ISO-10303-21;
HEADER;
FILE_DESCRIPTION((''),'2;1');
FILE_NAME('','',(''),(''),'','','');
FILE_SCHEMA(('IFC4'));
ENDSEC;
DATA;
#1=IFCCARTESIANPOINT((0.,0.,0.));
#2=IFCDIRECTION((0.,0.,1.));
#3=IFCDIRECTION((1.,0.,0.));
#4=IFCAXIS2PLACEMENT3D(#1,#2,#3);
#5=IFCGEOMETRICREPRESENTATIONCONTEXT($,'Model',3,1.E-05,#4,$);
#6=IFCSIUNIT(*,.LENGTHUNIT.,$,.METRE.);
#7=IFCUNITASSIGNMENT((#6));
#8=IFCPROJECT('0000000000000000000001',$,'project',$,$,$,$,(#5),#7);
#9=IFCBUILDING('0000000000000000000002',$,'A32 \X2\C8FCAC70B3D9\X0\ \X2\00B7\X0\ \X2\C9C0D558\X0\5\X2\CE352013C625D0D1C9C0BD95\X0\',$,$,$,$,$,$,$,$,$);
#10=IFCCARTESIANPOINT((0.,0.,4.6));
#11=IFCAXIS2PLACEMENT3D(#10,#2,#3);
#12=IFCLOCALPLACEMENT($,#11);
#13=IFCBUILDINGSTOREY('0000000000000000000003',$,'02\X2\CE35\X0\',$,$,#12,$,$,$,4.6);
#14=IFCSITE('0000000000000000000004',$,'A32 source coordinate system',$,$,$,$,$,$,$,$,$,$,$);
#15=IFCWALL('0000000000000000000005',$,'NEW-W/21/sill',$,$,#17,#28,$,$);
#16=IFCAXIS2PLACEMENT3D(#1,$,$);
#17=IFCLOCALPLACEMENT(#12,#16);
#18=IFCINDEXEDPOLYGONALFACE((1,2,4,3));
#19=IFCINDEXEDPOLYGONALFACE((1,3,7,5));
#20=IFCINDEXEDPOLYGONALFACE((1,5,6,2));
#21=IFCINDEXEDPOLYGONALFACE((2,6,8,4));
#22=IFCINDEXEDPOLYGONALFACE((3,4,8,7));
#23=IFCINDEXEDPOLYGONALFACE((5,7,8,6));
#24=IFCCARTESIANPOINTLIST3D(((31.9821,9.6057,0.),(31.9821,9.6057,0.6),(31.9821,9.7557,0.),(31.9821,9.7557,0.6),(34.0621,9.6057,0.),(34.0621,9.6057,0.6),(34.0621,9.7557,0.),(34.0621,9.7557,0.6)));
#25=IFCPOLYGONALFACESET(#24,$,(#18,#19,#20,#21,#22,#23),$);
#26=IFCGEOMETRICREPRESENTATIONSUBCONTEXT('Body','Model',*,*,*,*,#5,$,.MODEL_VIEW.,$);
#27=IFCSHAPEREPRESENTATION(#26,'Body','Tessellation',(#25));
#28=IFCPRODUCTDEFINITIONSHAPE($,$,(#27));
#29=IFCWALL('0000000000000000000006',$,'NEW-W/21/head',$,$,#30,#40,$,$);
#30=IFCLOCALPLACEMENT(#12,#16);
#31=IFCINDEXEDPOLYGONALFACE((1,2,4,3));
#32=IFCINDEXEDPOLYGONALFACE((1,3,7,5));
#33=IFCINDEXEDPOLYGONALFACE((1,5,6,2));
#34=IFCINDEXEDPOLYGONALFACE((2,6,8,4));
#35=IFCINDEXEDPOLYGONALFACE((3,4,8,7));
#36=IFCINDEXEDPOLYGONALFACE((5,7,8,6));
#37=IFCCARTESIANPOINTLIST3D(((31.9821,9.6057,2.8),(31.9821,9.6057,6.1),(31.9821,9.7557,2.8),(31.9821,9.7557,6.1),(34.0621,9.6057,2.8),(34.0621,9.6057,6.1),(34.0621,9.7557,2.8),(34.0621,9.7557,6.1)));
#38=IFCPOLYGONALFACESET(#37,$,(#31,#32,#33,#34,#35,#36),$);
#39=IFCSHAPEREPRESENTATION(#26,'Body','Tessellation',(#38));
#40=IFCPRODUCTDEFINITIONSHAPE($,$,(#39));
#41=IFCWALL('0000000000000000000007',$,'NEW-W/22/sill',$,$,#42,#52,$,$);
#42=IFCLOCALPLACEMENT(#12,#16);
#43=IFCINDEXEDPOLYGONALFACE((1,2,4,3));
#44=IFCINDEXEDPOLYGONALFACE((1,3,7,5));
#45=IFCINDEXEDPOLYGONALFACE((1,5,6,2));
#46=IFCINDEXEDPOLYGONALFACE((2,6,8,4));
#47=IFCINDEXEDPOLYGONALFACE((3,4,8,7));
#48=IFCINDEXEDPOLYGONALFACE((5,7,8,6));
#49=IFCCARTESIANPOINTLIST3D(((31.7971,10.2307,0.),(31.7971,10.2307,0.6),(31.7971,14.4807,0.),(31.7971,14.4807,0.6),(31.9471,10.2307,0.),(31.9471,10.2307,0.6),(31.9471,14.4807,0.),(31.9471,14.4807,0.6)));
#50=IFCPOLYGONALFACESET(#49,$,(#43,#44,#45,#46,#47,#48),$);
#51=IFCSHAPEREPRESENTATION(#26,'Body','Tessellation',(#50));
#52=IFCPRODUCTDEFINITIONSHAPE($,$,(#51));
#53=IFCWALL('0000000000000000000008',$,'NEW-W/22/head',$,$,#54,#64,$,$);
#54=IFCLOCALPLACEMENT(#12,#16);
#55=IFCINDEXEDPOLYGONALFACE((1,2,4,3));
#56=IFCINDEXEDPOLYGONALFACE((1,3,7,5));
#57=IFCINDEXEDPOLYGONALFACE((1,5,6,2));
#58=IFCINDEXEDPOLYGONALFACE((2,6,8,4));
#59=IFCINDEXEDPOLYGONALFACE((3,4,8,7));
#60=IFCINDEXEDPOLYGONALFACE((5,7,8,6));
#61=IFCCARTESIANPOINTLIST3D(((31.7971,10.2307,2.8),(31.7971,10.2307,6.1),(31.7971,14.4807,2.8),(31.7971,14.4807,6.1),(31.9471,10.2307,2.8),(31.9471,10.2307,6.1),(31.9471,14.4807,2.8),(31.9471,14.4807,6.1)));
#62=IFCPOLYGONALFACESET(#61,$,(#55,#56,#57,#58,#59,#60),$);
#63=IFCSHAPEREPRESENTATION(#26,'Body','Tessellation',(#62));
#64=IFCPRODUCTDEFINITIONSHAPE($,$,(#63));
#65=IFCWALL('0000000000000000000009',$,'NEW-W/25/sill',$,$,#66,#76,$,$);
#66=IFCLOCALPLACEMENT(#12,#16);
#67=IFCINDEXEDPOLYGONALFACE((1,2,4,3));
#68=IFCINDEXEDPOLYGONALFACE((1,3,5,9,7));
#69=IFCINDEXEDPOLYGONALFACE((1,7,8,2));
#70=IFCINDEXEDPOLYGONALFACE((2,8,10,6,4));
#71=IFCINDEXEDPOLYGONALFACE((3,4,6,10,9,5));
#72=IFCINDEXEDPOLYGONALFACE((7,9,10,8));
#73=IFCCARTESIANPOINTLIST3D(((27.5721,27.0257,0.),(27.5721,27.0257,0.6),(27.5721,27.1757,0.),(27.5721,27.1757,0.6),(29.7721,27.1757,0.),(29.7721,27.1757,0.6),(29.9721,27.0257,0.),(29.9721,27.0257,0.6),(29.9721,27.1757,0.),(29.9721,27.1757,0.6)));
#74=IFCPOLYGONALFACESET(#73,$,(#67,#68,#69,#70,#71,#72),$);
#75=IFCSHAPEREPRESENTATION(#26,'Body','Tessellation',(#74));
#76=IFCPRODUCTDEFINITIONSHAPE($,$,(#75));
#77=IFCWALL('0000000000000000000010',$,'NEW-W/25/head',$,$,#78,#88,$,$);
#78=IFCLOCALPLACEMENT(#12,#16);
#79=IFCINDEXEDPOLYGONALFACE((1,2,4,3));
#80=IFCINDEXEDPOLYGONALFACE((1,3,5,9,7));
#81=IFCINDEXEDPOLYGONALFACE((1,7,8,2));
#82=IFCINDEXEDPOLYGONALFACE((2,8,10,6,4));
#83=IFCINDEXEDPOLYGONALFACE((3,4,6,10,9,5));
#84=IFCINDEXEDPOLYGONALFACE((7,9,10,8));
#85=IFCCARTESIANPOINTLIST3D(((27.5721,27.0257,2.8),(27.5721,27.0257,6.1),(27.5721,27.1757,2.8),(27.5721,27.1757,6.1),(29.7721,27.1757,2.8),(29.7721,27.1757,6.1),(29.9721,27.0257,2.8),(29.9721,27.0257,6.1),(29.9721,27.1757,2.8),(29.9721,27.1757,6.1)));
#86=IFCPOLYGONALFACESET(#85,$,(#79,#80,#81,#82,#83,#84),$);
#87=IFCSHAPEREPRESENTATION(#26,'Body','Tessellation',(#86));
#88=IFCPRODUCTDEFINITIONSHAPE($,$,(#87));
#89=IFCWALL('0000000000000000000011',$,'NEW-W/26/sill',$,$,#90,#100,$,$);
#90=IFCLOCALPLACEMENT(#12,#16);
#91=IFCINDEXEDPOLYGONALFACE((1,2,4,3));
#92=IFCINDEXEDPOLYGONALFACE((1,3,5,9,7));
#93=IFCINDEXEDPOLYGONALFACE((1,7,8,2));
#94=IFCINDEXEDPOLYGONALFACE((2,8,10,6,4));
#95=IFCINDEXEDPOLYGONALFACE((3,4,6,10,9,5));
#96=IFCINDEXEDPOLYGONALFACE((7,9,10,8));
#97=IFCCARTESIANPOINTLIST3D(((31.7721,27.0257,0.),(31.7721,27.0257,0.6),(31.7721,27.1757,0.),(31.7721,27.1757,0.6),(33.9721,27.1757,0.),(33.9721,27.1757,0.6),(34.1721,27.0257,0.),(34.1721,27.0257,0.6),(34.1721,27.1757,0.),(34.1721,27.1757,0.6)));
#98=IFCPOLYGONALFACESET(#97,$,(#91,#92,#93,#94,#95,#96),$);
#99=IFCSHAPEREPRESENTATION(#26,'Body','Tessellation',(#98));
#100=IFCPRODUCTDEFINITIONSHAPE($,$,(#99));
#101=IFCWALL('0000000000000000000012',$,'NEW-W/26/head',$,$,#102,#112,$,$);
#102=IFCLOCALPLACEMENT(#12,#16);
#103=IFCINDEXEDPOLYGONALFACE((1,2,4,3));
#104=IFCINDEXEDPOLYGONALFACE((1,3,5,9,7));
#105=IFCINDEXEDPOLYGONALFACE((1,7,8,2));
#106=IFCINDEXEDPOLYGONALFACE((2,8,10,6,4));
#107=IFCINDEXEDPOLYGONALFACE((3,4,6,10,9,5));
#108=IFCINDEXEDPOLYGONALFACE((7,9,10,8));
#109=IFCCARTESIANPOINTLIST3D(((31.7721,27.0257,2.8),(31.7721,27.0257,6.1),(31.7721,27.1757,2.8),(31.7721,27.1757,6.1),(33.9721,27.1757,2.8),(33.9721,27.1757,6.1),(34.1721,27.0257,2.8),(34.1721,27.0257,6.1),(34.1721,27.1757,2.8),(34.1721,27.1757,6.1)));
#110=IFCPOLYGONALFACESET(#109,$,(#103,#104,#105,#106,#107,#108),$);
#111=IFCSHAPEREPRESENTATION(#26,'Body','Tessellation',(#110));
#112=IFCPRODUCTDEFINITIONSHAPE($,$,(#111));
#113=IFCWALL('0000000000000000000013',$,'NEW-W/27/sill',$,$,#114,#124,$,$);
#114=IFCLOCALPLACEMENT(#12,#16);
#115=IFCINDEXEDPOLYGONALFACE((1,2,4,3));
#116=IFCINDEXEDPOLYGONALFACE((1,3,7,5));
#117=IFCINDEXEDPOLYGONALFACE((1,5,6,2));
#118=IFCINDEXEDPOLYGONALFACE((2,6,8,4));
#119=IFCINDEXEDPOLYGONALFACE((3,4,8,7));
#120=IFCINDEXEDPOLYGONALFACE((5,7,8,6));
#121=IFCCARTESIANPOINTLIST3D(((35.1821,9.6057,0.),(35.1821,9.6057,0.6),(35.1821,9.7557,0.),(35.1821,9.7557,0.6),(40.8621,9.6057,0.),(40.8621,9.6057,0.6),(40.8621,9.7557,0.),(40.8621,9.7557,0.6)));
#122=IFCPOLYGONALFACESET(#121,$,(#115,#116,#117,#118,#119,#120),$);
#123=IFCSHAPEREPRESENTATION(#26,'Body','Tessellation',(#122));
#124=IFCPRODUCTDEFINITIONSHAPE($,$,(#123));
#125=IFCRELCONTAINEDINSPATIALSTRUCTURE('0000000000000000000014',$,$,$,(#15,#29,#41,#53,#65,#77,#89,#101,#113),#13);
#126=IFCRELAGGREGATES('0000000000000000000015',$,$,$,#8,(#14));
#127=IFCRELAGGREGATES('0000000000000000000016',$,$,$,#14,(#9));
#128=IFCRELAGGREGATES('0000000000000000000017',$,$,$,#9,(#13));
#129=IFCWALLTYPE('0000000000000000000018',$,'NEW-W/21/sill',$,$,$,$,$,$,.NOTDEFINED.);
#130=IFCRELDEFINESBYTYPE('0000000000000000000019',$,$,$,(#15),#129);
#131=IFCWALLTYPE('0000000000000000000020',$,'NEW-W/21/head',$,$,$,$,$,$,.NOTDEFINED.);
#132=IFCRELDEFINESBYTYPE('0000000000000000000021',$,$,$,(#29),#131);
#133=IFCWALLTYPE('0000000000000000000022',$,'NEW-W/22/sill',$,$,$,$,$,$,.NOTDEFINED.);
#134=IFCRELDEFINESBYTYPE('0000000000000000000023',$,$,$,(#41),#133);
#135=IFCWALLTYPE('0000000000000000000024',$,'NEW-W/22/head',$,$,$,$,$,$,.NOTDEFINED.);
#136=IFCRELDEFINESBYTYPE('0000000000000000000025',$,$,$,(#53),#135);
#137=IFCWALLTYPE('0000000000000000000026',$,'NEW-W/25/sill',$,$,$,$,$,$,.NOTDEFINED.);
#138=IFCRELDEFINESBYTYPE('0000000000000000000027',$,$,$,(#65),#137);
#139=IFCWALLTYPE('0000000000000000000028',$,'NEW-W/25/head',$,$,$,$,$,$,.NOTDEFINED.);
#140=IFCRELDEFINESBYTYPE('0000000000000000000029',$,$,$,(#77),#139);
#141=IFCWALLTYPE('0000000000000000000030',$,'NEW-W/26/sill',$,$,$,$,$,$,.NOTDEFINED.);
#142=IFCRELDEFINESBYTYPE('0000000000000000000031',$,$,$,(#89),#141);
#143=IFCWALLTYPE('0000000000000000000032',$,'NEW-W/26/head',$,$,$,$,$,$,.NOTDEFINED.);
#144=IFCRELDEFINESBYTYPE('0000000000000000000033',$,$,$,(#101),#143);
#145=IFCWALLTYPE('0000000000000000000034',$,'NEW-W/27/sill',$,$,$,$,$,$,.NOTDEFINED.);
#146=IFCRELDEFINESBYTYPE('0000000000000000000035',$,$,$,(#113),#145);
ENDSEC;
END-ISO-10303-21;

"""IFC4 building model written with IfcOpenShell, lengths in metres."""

from ifc_helpers import new_model, si_unit, frame, origin, origin_with_axes, place, context, subcontext, project, spatial, polyline, outline, extrude, source, transform, mapped, type_object, type_shapes, element, save


model = new_model("IFC4")

# Units and contexts
model_context = context("Model", 3, precision=1e-05, world=origin_with_axes())
body_context = subcontext(model_context, "Body", "Model", "MODEL_VIEW")
ifc_project = project(units=[si_unit("LENGTHUNIT", "METRE")], contexts=[model_context])

# Site, building, storey
site = spatial("IfcSite", under=ifc_project, Name="A32 source coordinate system")
building = spatial("IfcBuilding", under=site, Name="A32 주거동 · 지하5층–옥탑지붕")
storey_placement = place(None, frame((0.0, 0.0, 4.6), z_axis=(0.0, 0.0, 1.0), x_axis=(1.0, 0.0, 0.0)))
storey = spatial("IfcBuildingStorey", under=building, at=storey_placement, Name="02층", Elevation=4.6)

# Walls
wall_type_1 = type_object("IfcWallType", Name="NEW-W/21/sill", PredefinedType="NOTDEFINED")
shared_shape_1 = source(origin(), body_context, "Body", "SweptSolid", [
    extrude(outline(polyline([(31.9821, 9.6057), (31.9821, 9.7557), (34.0621, 9.7557), (34.0621, 9.6057), (31.9821, 9.6057)])), origin(), (0.0, 0.0, 1.0), 0.6),
])
type_shapes(wall_type_1, [shared_shape_1])
wall_1_placement = place(storey_placement, origin_with_axes())
element("IfcWall", 1, at=wall_1_placement, inside=storey, type_object=wall_type_1, Name="NEW-W/21/sill", context=body_context, shape_type="MappedRepresentation", body=[
    mapped(shared_shape_1, transform((0.0, 0.0, 0.0), scale=1.0)),
])
wall_type_2 = type_object("IfcWallType", Name="NEW-W/21/head", PredefinedType="NOTDEFINED")
shared_shape_2 = source(origin(), body_context, "Body", "SweptSolid", [
    extrude(outline(polyline([(31.9821, 9.6057), (31.9821, 9.7557), (34.0621, 9.7557), (34.0621, 9.6057), (31.9821, 9.6057)])), frame((0.0, 0.0, 2.8)), (0.0, 0.0, 1.0), 3.3),
])
type_shapes(wall_type_2, [shared_shape_2])
wall_2_placement = place(storey_placement, origin_with_axes())
element("IfcWall", 2, at=wall_2_placement, inside=storey, type_object=wall_type_2, Name="NEW-W/21/head", context=body_context, shape_type="MappedRepresentation", body=[
    mapped(shared_shape_2, transform((0.0, 0.0, 0.0), scale=1.0)),
])
wall_type_3 = type_object("IfcWallType", Name="NEW-W/22/sill", PredefinedType="NOTDEFINED")
shared_shape_3 = source(origin(), body_context, "Body", "SweptSolid", [
    extrude(outline(polyline([(31.7971, 10.2307), (31.7971, 14.4807), (31.9471, 14.4807), (31.9471, 10.2307), (31.7971, 10.2307)])), origin(), (0.0, 0.0, 1.0), 0.6),
])
type_shapes(wall_type_3, [shared_shape_3])
wall_3_placement = place(storey_placement, origin_with_axes())
element("IfcWall", 3, at=wall_3_placement, inside=storey, type_object=wall_type_3, Name="NEW-W/22/sill", context=body_context, shape_type="MappedRepresentation", body=[
    mapped(shared_shape_3, transform((0.0, 0.0, 0.0), scale=1.0)),
])
wall_type_4 = type_object("IfcWallType", Name="NEW-W/22/head", PredefinedType="NOTDEFINED")
shared_shape_4 = source(origin(), body_context, "Body", "SweptSolid", [
    extrude(outline(polyline([(31.7971, 10.2307), (31.7971, 14.4807), (31.9471, 14.4807), (31.9471, 10.2307), (31.7971, 10.2307)])), frame((0.0, 0.0, 2.8)), (0.0, 0.0, 1.0), 3.3),
])
type_shapes(wall_type_4, [shared_shape_4])
wall_4_placement = place(storey_placement, origin_with_axes())
element("IfcWall", 4, at=wall_4_placement, inside=storey, type_object=wall_type_4, Name="NEW-W/22/head", context=body_context, shape_type="MappedRepresentation", body=[
    mapped(shared_shape_4, transform((0.0, 0.0, 0.0), scale=1.0)),
])
wall_type_5 = type_object("IfcWallType", Name="NEW-W/25/sill", PredefinedType="NOTDEFINED")
shared_shape_5 = source(origin(), body_context, "Body", "SweptSolid", [
    extrude(outline(polyline([(29.9721, 27.0257), (27.5721, 27.0257), (27.5721, 27.1757), (29.7721, 27.1757), (29.7721, 27.1757), (29.9721, 27.1757), (29.9721, 27.0257)])), origin(), (0.0, 0.0, 1.0), 0.6),
])
type_shapes(wall_type_5, [shared_shape_5])
wall_5_placement = place(storey_placement, origin_with_axes())
element("IfcWall", 5, at=wall_5_placement, inside=storey, type_object=wall_type_5, Name="NEW-W/25/sill", context=body_context, shape_type="MappedRepresentation", body=[
    mapped(shared_shape_5, transform((0.0, 0.0, 0.0), scale=1.0)),
])
wall_type_6 = type_object("IfcWallType", Name="NEW-W/25/head", PredefinedType="NOTDEFINED")
shared_shape_6 = source(origin(), body_context, "Body", "SweptSolid", [
    extrude(outline(polyline([(29.9721, 27.0257), (27.5721, 27.0257), (27.5721, 27.1757), (29.7721, 27.1757), (29.7721, 27.1757), (29.9721, 27.1757), (29.9721, 27.0257)])), frame((0.0, 0.0, 2.8)), (0.0, 0.0, 1.0), 3.3),
])
type_shapes(wall_type_6, [shared_shape_6])
wall_6_placement = place(storey_placement, origin_with_axes())
element("IfcWall", 6, at=wall_6_placement, inside=storey, type_object=wall_type_6, Name="NEW-W/25/head", context=body_context, shape_type="MappedRepresentation", body=[
    mapped(shared_shape_6, transform((0.0, 0.0, 0.0), scale=1.0)),
])
wall_type_7 = type_object("IfcWallType", Name="NEW-W/26/sill", PredefinedType="NOTDEFINED")
shared_shape_7 = source(origin(), body_context, "Body", "SweptSolid", [
    extrude(outline(polyline([(34.1721, 27.0257), (31.7721, 27.0257), (31.7721, 27.1757), (33.9721, 27.1757), (33.9721, 27.1757), (34.1721, 27.1757), (34.1721, 27.0257)])), origin(), (0.0, 0.0, 1.0), 0.6),
])
type_shapes(wall_type_7, [shared_shape_7])
wall_7_placement = place(storey_placement, origin_with_axes())
element("IfcWall", 7, at=wall_7_placement, inside=storey, type_object=wall_type_7, Name="NEW-W/26/sill", context=body_context, shape_type="MappedRepresentation", body=[
    mapped(shared_shape_7, transform((0.0, 0.0, 0.0), scale=1.0)),
])
wall_type_8 = type_object("IfcWallType", Name="NEW-W/26/head", PredefinedType="NOTDEFINED")
shared_shape_8 = source(origin(), body_context, "Body", "SweptSolid", [
    extrude(outline(polyline([(34.1721, 27.0257), (31.7721, 27.0257), (31.7721, 27.1757), (33.9721, 27.1757), (33.9721, 27.1757), (34.1721, 27.1757), (34.1721, 27.0257)])), frame((0.0, 0.0, 2.8)), (0.0, 0.0, 1.0), 3.3),
])
type_shapes(wall_type_8, [shared_shape_8])
wall_8_placement = place(storey_placement, origin_with_axes())
element("IfcWall", 8, at=wall_8_placement, inside=storey, type_object=wall_type_8, Name="NEW-W/26/head", context=body_context, shape_type="MappedRepresentation", body=[
    mapped(shared_shape_8, transform((0.0, 0.0, 0.0), scale=1.0)),
])
wall_type_9 = type_object("IfcWallType", Name="NEW-W/27/sill", PredefinedType="NOTDEFINED")
shared_shape_9 = source(origin(), body_context, "Body", "SweptSolid", [
    extrude(outline(polyline([(35.1821, 9.6057), (35.1821, 9.7557), (40.8621, 9.7557), (40.8621, 9.6057), (35.1821, 9.6057)])), origin(), (0.0, 0.0, 1.0), 0.6),
])
type_shapes(wall_type_9, [shared_shape_9])
wall_9_placement = place(storey_placement, origin_with_axes())
element("IfcWall", 9, at=wall_9_placement, inside=storey, type_object=wall_type_9, Name="NEW-W/27/sill", context=body_context, shape_type="MappedRepresentation", body=[
    mapped(shared_shape_9, transform((0.0, 0.0, 0.0), scale=1.0)),
])

save(model, "model.ifc")
